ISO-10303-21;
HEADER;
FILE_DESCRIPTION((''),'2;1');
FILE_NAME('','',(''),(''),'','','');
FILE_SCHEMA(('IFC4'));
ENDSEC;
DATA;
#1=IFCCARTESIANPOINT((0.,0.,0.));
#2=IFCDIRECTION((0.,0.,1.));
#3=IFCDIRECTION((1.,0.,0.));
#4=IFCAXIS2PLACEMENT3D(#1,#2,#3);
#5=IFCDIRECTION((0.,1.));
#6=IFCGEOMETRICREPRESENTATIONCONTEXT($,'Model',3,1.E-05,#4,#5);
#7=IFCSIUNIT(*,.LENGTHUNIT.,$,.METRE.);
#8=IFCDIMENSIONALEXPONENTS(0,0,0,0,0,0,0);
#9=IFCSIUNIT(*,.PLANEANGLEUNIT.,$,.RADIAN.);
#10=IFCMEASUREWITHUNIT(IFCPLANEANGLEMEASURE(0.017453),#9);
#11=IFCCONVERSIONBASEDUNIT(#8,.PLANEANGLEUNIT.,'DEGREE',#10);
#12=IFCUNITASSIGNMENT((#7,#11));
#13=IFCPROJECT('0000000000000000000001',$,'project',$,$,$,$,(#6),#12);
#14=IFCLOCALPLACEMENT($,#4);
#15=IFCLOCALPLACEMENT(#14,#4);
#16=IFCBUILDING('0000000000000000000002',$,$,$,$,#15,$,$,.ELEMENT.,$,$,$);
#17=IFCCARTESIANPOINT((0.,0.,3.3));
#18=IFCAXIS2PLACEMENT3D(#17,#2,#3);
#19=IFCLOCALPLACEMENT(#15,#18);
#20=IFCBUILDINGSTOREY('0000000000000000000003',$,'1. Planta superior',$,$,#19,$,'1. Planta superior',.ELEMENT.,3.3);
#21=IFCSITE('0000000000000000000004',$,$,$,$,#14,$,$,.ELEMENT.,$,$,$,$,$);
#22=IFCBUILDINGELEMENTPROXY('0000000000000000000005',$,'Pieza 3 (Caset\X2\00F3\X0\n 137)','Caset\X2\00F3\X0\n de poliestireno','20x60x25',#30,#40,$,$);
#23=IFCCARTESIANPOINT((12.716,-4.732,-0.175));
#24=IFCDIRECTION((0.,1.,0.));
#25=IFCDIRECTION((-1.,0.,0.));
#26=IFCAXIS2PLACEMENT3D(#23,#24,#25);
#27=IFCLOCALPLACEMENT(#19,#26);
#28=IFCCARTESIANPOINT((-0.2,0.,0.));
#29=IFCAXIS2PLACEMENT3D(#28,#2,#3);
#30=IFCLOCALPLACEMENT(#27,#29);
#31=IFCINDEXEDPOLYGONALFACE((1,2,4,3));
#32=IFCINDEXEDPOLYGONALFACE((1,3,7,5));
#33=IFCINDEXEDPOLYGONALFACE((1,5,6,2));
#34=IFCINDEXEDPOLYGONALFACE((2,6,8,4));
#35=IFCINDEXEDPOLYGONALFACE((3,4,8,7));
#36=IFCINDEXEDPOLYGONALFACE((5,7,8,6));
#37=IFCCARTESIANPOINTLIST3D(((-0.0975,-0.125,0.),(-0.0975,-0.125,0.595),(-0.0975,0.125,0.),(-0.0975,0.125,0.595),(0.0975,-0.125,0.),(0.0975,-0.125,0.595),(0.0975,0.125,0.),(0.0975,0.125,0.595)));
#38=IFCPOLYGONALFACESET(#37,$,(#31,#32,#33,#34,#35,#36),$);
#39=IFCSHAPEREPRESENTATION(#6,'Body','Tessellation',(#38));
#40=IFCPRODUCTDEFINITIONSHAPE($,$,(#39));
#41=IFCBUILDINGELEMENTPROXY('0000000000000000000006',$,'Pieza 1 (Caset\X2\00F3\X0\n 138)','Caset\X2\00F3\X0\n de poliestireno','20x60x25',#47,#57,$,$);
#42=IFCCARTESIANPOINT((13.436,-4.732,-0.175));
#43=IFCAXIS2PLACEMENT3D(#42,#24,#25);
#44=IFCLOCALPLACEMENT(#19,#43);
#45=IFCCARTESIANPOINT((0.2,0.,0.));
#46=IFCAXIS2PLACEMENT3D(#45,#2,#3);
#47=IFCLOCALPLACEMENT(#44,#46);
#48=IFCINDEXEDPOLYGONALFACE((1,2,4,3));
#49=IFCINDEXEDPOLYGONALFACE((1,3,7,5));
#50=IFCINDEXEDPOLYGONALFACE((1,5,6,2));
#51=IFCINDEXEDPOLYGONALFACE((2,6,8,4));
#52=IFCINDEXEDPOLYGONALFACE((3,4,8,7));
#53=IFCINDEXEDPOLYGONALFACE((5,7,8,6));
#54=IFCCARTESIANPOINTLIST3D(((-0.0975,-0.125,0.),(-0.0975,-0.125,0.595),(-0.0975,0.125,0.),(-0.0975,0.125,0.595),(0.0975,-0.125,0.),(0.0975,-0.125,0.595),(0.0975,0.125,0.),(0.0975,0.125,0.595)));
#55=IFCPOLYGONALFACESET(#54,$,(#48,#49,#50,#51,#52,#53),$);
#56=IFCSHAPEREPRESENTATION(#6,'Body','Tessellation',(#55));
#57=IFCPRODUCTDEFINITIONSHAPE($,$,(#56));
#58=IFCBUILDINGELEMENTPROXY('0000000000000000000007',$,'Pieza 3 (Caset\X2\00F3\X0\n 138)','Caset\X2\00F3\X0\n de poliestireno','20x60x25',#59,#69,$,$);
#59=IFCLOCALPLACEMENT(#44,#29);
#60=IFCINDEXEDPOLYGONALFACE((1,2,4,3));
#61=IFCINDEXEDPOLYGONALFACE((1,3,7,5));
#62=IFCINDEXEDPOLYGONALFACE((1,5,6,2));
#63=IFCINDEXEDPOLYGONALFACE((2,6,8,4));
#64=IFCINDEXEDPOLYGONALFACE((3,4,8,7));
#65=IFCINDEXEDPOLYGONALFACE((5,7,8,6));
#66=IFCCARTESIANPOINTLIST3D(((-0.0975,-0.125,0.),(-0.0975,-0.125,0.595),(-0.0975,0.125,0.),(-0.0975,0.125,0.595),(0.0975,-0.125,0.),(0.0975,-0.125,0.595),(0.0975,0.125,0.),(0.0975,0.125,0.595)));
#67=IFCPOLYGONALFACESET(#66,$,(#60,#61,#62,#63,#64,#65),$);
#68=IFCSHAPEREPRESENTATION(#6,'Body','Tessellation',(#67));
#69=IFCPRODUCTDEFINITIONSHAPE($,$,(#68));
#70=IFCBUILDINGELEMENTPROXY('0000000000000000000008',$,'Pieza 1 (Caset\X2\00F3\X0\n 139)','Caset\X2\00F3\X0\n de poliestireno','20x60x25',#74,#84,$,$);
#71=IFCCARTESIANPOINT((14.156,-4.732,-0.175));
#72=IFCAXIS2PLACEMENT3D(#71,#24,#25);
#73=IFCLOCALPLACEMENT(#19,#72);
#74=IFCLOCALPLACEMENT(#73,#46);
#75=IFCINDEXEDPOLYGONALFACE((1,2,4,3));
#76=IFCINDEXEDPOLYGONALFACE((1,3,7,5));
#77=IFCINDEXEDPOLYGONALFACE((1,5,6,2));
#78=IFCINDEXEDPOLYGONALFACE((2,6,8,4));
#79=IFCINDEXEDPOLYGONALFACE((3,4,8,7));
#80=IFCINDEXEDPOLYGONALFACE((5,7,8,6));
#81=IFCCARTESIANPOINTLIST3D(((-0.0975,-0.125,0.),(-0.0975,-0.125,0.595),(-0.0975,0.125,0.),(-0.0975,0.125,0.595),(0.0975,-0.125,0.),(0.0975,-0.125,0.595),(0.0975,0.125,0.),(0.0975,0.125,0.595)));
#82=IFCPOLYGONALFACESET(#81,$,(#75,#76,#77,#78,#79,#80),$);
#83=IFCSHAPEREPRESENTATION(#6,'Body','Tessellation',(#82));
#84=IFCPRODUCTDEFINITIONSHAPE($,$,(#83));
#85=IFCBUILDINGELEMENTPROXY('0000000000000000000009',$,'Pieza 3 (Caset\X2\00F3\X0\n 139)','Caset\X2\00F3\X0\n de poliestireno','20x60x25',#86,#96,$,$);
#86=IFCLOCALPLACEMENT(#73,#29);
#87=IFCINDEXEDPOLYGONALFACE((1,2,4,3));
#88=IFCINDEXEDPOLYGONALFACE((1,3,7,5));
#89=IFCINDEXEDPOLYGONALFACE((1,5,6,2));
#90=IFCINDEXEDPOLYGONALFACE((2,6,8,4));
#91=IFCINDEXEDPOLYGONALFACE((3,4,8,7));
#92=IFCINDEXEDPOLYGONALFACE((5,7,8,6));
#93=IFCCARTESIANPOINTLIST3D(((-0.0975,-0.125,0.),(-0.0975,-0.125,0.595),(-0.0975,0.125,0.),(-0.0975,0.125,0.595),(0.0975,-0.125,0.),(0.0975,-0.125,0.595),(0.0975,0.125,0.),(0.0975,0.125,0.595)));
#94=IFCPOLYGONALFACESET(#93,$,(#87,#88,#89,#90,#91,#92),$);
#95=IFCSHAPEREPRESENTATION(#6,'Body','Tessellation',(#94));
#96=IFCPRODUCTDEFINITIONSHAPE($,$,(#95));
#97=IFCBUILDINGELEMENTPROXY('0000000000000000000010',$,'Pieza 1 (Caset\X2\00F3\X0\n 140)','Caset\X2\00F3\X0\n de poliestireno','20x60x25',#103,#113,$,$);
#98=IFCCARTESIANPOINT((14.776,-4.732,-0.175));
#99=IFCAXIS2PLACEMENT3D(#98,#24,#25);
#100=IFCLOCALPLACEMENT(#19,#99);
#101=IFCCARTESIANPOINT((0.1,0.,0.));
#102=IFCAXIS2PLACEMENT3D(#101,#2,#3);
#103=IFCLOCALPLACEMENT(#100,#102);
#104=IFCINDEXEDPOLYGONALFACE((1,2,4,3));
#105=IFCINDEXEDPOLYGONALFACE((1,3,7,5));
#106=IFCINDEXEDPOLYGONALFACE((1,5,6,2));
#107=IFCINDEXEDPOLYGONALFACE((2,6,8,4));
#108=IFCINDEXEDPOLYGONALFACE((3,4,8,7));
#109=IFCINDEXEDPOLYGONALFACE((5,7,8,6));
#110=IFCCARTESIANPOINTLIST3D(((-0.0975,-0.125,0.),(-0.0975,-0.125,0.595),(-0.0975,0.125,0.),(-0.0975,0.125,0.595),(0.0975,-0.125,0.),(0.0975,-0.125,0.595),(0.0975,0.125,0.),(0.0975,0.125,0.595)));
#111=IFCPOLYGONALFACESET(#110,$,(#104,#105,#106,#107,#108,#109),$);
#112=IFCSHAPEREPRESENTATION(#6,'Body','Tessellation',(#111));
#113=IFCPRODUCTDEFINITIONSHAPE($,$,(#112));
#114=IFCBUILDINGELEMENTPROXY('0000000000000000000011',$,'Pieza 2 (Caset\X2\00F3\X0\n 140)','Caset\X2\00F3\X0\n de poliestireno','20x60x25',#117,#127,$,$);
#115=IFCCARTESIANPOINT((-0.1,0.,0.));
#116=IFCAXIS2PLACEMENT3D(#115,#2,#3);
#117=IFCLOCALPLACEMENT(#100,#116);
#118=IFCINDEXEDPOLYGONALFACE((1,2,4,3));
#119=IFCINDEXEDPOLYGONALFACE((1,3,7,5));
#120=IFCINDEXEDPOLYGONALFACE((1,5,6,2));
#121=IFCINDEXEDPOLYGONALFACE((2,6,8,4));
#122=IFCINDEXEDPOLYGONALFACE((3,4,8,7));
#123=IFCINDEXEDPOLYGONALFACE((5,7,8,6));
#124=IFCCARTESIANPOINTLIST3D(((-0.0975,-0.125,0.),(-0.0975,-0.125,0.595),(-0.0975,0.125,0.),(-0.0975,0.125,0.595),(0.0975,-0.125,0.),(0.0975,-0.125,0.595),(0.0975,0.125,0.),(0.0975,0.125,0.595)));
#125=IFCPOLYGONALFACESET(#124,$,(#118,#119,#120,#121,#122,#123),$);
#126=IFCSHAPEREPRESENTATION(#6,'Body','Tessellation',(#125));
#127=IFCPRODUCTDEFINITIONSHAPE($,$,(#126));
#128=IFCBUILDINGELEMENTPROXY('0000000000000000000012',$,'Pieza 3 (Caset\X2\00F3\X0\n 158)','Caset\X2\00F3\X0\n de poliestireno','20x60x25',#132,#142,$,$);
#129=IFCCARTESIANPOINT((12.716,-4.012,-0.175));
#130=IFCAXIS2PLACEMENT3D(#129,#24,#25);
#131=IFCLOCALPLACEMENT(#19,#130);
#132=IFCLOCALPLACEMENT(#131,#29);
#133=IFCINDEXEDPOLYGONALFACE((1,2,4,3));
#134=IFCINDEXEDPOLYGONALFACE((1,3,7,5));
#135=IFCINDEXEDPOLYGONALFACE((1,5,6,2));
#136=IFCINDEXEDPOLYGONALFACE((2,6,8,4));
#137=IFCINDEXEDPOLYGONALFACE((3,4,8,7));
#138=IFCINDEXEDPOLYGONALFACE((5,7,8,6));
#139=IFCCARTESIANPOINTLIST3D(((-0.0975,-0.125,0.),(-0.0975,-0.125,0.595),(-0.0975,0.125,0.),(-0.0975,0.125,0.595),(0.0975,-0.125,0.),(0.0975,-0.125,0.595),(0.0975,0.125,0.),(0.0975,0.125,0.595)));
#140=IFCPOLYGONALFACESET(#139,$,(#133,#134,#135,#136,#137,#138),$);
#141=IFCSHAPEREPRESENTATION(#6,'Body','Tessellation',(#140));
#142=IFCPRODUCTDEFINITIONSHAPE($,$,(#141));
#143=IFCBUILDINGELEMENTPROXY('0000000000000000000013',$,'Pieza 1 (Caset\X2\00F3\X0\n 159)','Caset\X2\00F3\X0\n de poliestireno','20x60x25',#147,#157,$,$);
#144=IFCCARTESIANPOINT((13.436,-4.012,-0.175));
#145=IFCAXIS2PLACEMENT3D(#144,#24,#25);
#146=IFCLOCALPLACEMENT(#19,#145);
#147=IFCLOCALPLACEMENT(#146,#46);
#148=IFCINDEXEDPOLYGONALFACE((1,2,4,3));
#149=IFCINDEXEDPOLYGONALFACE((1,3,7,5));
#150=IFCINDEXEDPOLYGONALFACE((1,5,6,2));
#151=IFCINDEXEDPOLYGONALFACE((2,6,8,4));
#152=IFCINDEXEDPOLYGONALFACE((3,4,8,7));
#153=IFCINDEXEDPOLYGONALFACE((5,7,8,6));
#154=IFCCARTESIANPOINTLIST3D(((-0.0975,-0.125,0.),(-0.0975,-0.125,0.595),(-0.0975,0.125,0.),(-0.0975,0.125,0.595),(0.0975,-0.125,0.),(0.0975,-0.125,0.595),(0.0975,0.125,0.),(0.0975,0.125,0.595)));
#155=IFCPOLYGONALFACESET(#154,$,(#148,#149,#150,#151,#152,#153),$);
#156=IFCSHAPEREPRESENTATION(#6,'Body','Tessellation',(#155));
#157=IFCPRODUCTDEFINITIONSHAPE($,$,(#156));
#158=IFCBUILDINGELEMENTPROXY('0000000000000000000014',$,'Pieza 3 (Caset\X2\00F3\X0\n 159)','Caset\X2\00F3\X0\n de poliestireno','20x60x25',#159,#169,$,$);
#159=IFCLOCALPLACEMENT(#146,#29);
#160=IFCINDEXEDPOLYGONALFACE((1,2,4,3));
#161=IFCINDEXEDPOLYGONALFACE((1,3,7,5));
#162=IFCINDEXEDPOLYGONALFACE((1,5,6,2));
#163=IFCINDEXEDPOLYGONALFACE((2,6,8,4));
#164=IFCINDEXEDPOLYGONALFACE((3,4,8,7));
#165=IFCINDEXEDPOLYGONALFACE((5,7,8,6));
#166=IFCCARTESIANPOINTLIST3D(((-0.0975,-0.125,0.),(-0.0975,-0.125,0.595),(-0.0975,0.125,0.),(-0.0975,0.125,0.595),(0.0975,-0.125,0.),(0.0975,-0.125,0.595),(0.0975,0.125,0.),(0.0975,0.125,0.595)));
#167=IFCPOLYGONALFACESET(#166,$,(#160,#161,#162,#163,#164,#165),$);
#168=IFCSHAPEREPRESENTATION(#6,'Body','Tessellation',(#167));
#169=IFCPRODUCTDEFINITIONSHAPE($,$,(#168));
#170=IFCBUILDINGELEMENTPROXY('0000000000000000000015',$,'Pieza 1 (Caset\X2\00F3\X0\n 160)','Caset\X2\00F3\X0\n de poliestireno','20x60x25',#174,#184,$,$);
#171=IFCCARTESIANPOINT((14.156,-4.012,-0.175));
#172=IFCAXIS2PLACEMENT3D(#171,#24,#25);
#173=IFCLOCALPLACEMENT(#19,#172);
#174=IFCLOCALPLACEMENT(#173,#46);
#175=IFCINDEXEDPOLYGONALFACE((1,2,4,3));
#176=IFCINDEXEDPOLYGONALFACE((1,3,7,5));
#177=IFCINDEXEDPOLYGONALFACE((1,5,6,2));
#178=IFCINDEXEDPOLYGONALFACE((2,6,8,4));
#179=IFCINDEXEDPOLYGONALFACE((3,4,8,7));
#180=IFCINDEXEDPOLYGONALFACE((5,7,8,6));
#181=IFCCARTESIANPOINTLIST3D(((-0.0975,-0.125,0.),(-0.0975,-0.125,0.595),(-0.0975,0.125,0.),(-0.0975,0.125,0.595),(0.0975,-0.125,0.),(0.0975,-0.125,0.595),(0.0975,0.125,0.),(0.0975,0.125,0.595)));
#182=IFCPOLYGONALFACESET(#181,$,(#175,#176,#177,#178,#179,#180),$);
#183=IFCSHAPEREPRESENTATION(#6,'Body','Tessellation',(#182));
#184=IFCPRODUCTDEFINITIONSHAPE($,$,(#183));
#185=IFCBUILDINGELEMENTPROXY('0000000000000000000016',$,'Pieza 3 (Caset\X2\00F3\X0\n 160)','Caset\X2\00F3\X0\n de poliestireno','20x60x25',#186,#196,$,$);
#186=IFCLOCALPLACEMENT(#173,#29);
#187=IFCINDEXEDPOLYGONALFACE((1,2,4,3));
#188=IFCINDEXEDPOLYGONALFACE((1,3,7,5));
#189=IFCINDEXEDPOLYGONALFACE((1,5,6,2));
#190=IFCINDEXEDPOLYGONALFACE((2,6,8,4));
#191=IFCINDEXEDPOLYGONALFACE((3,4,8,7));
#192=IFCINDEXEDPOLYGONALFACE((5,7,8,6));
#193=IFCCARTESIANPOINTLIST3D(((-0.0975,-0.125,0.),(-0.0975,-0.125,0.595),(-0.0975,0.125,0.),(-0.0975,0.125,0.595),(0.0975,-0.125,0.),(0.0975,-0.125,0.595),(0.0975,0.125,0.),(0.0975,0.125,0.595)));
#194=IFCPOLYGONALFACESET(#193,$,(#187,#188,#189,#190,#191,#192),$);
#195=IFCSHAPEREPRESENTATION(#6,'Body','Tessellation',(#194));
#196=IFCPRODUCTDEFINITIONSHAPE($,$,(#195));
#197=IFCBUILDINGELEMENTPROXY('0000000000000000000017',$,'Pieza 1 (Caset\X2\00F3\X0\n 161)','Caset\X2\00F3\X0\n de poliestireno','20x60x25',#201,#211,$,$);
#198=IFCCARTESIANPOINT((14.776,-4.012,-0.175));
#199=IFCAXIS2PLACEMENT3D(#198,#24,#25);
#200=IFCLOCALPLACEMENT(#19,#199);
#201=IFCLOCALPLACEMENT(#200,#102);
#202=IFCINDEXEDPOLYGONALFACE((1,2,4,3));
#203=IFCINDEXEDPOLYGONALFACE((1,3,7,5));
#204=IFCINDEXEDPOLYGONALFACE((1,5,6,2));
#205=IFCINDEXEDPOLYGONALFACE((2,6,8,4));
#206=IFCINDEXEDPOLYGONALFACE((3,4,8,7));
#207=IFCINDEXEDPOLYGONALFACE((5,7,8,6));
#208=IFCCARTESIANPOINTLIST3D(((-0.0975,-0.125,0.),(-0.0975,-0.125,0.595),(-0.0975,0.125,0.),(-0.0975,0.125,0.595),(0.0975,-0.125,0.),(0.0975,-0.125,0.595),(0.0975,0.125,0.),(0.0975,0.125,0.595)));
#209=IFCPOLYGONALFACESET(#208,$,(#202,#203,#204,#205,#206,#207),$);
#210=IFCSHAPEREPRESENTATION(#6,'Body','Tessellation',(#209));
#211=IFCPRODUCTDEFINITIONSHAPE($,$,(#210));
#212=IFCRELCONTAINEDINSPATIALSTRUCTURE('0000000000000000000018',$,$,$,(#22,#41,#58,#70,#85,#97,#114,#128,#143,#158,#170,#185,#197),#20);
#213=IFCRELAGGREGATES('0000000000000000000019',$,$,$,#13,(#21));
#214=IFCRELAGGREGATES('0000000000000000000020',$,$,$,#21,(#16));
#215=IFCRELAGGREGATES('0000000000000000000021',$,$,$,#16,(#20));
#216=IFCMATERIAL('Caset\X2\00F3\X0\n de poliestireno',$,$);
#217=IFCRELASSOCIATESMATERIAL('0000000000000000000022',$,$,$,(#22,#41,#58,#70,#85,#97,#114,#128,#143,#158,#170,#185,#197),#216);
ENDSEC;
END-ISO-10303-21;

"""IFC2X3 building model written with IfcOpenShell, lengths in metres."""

from ifc_helpers import new_model, entity, si_unit, converted_unit, direction, frame, origin_with_axes, origin_2d_with_axis, place, context, project, spatial, rectangle, extrude, source, transform, mapped, material, element, save


model = new_model("IFC2X3")

# Units and contexts
model_context = context("Model", 3, precision=1e-05, world=origin_with_axes(), true_north=direction((0.0, 1.0)))
ifc_project = project(units=[si_unit("LENGTHUNIT", "METRE"), converted_unit("PLANEANGLEUNIT", "DEGREE", entity("IfcPlaneAngleMeasure", 0.017453), si_unit("PLANEANGLEUNIT", "RADIAN"), dimensions=[0, 0, 0, 0, 0, 0, 0])], contexts=[model_context])

# Site, building, storey
site_placement = place(None, origin_with_axes())
site = spatial("IfcSite", under=ifc_project, at=site_placement, CompositionType="ELEMENT")
building_placement = place(site_placement, origin_with_axes())
building = spatial("IfcBuilding", under=site, at=building_placement, CompositionType="ELEMENT")
storey_placement = place(building_placement, frame((0.0, 0.0, 3.3), z_axis=(0.0, 0.0, 1.0), x_axis=(1.0, 0.0, 0.0)))
storey = spatial("IfcBuildingStorey", under=building, at=storey_placement, Name="1. Planta superior", LongName="1. Planta superior", CompositionType="ELEMENT", Elevation=3.3)

# Building element proxies
ifc_material = material(Name="Casetón de poliestireno")
shared_shape = source(origin_with_axes(), model_context, "Body", "SweptSolid", [
    extrude(rectangle(XDim=0.195, YDim=0.25, at=origin_2d_with_axis()), origin_with_axes(), (0.0, 0.0, 1.0), 0.595),
])
placement_1 = place(storey_placement, frame((12.716, -4.732, -0.175), z_axis=(0.0, 1.0, 0.0), x_axis=(-1.0, 0.0, 0.0)))
for number, where, z_axis, x_axis, name in (
    (1, (-0.2, 0.0, 0.0), (0.0, 0.0, 1.0), (1.0, 0.0, 0.0), "Pieza 3 (Casetón 137)"),
):
    element("IfcBuildingElementProxy", number, at=place(placement_1, frame(where, z_axis=z_axis, x_axis=x_axis)), inside=storey, material=ifc_material, Name=name, Description="Casetón de poliestireno", ObjectType="20x60x25", context=model_context, shape_type="MappedRepresentation", body=[
        mapped(shared_shape, transform((0.0, 0.0, 0.0), x_axis=(1.0, 0.0, 0.0), y_axis=(0.0, 1.0, 0.0), z_axis=(0.0, 0.0, 1.0))),
    ])
placement_2 = place(storey_placement, frame((13.436, -4.732, -0.175), z_axis=(0.0, 1.0, 0.0), x_axis=(-1.0, 0.0, 0.0)))
for number, where, z_axis, x_axis, name in (
    (2, (0.2, 0.0, 0.0), (0.0, 0.0, 1.0), (1.0, 0.0, 0.0), "Pieza 1 (Casetón 138)"),
    (3, (-0.2, 0.0, 0.0), (0.0, 0.0, 1.0), (1.0, 0.0, 0.0), "Pieza 3 (Casetón 138)"),
):
    element("IfcBuildingElementProxy", number, at=place(placement_2, frame(where, z_axis=z_axis, x_axis=x_axis)), inside=storey, material=ifc_material, Name=name, Description="Casetón de poliestireno", ObjectType="20x60x25", context=model_context, shape_type="MappedRepresentation", body=[
        mapped(shared_shape, transform((0.0, 0.0, 0.0), x_axis=(1.0, 0.0, 0.0), y_axis=(0.0, 1.0, 0.0), z_axis=(0.0, 0.0, 1.0))),
    ])
placement_3 = place(storey_placement, frame((14.156, -4.732, -0.175), z_axis=(0.0, 1.0, 0.0), x_axis=(-1.0, 0.0, 0.0)))
for number, where, z_axis, x_axis, name in (
    (4, (0.2, 0.0, 0.0), (0.0, 0.0, 1.0), (1.0, 0.0, 0.0), "Pieza 1 (Casetón 139)"),
    (5, (-0.2, 0.0, 0.0), (0.0, 0.0, 1.0), (1.0, 0.0, 0.0), "Pieza 3 (Casetón 139)"),
):
    element("IfcBuildingElementProxy", number, at=place(placement_3, frame(where, z_axis=z_axis, x_axis=x_axis)), inside=storey, material=ifc_material, Name=name, Description="Casetón de poliestireno", ObjectType="20x60x25", context=model_context, shape_type="MappedRepresentation", body=[
        mapped(shared_shape, transform((0.0, 0.0, 0.0), x_axis=(1.0, 0.0, 0.0), y_axis=(0.0, 1.0, 0.0), z_axis=(0.0, 0.0, 1.0))),
    ])
placement_4 = place(storey_placement, frame((14.776, -4.732, -0.175), z_axis=(0.0, 1.0, 0.0), x_axis=(-1.0, 0.0, 0.0)))
for number, where, z_axis, x_axis, name in (
    (6, (0.1, 0.0, 0.0), (0.0, 0.0, 1.0), (1.0, 0.0, 0.0), "Pieza 1 (Casetón 140)"),
    (7, (-0.1, 0.0, 0.0), (0.0, 0.0, 1.0), (1.0, 0.0, 0.0), "Pieza 2 (Casetón 140)"),
):
    element("IfcBuildingElementProxy", number, at=place(placement_4, frame(where, z_axis=z_axis, x_axis=x_axis)), inside=storey, material=ifc_material, Name=name, Description="Casetón de poliestireno", ObjectType="20x60x25", context=model_context, shape_type="MappedRepresentation", body=[
        mapped(shared_shape, transform((0.0, 0.0, 0.0), x_axis=(1.0, 0.0, 0.0), y_axis=(0.0, 1.0, 0.0), z_axis=(0.0, 0.0, 1.0))),
    ])
placement_5 = place(storey_placement, frame((12.716, -4.012, -0.175), z_axis=(0.0, 1.0, 0.0), x_axis=(-1.0, 0.0, 0.0)))
for number, where, z_axis, x_axis, name in (
    (8, (-0.2, 0.0, 0.0), (0.0, 0.0, 1.0), (1.0, 0.0, 0.0), "Pieza 3 (Casetón 158)"),
):
    element("IfcBuildingElementProxy", number, at=place(placement_5, frame(where, z_axis=z_axis, x_axis=x_axis)), inside=storey, material=ifc_material, Name=name, Description="Casetón de poliestireno", ObjectType="20x60x25", context=model_context, shape_type="MappedRepresentation", body=[
        mapped(shared_shape, transform((0.0, 0.0, 0.0), x_axis=(1.0, 0.0, 0.0), y_axis=(0.0, 1.0, 0.0), z_axis=(0.0, 0.0, 1.0))),
    ])
placement_6 = place(storey_placement, frame((13.436, -4.012, -0.175), z_axis=(0.0, 1.0, 0.0), x_axis=(-1.0, 0.0, 0.0)))
for number, where, z_axis, x_axis, name in (
    (9, (0.2, 0.0, 0.0), (0.0, 0.0, 1.0), (1.0, 0.0, 0.0), "Pieza 1 (Casetón 159)"),
    (10, (-0.2, 0.0, 0.0), (0.0, 0.0, 1.0), (1.0, 0.0, 0.0), "Pieza 3 (Casetón 159)"),
):
    element("IfcBuildingElementProxy", number, at=place(placement_6, frame(where, z_axis=z_axis, x_axis=x_axis)), inside=storey, material=ifc_material, Name=name, Description="Casetón de poliestireno", ObjectType="20x60x25", context=model_context, shape_type="MappedRepresentation", body=[
        mapped(shared_shape, transform((0.0, 0.0, 0.0), x_axis=(1.0, 0.0, 0.0), y_axis=(0.0, 1.0, 0.0), z_axis=(0.0, 0.0, 1.0))),
    ])
placement_7 = place(storey_placement, frame((14.156, -4.012, -0.175), z_axis=(0.0, 1.0, 0.0), x_axis=(-1.0, 0.0, 0.0)))
for number, where, z_axis, x_axis, name in (
    (11, (0.2, 0.0, 0.0), (0.0, 0.0, 1.0), (1.0, 0.0, 0.0), "Pieza 1 (Casetón 160)"),
    (12, (-0.2, 0.0, 0.0), (0.0, 0.0, 1.0), (1.0, 0.0, 0.0), "Pieza 3 (Casetón 160)"),
):
    element("IfcBuildingElementProxy", number, at=place(placement_7, frame(where, z_axis=z_axis, x_axis=x_axis)), inside=storey, material=ifc_material, Name=name, Description="Casetón de poliestireno", ObjectType="20x60x25", context=model_context, shape_type="MappedRepresentation", body=[
        mapped(shared_shape, transform((0.0, 0.0, 0.0), x_axis=(1.0, 0.0, 0.0), y_axis=(0.0, 1.0, 0.0), z_axis=(0.0, 0.0, 1.0))),
    ])
placement_8 = place(storey_placement, frame((14.776, -4.012, -0.175), z_axis=(0.0, 1.0, 0.0), x_axis=(-1.0, 0.0, 0.0)))
for number, where, z_axis, x_axis, name in (
    (13, (0.1, 0.0, 0.0), (0.0, 0.0, 1.0), (1.0, 0.0, 0.0), "Pieza 1 (Casetón 161)"),
):
    element("IfcBuildingElementProxy", number, at=place(placement_8, frame(where, z_axis=z_axis, x_axis=x_axis)), inside=storey, material=ifc_material, Name=name, Description="Casetón de poliestireno", ObjectType="20x60x25", context=model_context, shape_type="MappedRepresentation", body=[
        mapped(shared_shape, transform((0.0, 0.0, 0.0), x_axis=(1.0, 0.0, 0.0), y_axis=(0.0, 1.0, 0.0), z_axis=(0.0, 0.0, 1.0))),
    ])

save(model, "model.ifc")
